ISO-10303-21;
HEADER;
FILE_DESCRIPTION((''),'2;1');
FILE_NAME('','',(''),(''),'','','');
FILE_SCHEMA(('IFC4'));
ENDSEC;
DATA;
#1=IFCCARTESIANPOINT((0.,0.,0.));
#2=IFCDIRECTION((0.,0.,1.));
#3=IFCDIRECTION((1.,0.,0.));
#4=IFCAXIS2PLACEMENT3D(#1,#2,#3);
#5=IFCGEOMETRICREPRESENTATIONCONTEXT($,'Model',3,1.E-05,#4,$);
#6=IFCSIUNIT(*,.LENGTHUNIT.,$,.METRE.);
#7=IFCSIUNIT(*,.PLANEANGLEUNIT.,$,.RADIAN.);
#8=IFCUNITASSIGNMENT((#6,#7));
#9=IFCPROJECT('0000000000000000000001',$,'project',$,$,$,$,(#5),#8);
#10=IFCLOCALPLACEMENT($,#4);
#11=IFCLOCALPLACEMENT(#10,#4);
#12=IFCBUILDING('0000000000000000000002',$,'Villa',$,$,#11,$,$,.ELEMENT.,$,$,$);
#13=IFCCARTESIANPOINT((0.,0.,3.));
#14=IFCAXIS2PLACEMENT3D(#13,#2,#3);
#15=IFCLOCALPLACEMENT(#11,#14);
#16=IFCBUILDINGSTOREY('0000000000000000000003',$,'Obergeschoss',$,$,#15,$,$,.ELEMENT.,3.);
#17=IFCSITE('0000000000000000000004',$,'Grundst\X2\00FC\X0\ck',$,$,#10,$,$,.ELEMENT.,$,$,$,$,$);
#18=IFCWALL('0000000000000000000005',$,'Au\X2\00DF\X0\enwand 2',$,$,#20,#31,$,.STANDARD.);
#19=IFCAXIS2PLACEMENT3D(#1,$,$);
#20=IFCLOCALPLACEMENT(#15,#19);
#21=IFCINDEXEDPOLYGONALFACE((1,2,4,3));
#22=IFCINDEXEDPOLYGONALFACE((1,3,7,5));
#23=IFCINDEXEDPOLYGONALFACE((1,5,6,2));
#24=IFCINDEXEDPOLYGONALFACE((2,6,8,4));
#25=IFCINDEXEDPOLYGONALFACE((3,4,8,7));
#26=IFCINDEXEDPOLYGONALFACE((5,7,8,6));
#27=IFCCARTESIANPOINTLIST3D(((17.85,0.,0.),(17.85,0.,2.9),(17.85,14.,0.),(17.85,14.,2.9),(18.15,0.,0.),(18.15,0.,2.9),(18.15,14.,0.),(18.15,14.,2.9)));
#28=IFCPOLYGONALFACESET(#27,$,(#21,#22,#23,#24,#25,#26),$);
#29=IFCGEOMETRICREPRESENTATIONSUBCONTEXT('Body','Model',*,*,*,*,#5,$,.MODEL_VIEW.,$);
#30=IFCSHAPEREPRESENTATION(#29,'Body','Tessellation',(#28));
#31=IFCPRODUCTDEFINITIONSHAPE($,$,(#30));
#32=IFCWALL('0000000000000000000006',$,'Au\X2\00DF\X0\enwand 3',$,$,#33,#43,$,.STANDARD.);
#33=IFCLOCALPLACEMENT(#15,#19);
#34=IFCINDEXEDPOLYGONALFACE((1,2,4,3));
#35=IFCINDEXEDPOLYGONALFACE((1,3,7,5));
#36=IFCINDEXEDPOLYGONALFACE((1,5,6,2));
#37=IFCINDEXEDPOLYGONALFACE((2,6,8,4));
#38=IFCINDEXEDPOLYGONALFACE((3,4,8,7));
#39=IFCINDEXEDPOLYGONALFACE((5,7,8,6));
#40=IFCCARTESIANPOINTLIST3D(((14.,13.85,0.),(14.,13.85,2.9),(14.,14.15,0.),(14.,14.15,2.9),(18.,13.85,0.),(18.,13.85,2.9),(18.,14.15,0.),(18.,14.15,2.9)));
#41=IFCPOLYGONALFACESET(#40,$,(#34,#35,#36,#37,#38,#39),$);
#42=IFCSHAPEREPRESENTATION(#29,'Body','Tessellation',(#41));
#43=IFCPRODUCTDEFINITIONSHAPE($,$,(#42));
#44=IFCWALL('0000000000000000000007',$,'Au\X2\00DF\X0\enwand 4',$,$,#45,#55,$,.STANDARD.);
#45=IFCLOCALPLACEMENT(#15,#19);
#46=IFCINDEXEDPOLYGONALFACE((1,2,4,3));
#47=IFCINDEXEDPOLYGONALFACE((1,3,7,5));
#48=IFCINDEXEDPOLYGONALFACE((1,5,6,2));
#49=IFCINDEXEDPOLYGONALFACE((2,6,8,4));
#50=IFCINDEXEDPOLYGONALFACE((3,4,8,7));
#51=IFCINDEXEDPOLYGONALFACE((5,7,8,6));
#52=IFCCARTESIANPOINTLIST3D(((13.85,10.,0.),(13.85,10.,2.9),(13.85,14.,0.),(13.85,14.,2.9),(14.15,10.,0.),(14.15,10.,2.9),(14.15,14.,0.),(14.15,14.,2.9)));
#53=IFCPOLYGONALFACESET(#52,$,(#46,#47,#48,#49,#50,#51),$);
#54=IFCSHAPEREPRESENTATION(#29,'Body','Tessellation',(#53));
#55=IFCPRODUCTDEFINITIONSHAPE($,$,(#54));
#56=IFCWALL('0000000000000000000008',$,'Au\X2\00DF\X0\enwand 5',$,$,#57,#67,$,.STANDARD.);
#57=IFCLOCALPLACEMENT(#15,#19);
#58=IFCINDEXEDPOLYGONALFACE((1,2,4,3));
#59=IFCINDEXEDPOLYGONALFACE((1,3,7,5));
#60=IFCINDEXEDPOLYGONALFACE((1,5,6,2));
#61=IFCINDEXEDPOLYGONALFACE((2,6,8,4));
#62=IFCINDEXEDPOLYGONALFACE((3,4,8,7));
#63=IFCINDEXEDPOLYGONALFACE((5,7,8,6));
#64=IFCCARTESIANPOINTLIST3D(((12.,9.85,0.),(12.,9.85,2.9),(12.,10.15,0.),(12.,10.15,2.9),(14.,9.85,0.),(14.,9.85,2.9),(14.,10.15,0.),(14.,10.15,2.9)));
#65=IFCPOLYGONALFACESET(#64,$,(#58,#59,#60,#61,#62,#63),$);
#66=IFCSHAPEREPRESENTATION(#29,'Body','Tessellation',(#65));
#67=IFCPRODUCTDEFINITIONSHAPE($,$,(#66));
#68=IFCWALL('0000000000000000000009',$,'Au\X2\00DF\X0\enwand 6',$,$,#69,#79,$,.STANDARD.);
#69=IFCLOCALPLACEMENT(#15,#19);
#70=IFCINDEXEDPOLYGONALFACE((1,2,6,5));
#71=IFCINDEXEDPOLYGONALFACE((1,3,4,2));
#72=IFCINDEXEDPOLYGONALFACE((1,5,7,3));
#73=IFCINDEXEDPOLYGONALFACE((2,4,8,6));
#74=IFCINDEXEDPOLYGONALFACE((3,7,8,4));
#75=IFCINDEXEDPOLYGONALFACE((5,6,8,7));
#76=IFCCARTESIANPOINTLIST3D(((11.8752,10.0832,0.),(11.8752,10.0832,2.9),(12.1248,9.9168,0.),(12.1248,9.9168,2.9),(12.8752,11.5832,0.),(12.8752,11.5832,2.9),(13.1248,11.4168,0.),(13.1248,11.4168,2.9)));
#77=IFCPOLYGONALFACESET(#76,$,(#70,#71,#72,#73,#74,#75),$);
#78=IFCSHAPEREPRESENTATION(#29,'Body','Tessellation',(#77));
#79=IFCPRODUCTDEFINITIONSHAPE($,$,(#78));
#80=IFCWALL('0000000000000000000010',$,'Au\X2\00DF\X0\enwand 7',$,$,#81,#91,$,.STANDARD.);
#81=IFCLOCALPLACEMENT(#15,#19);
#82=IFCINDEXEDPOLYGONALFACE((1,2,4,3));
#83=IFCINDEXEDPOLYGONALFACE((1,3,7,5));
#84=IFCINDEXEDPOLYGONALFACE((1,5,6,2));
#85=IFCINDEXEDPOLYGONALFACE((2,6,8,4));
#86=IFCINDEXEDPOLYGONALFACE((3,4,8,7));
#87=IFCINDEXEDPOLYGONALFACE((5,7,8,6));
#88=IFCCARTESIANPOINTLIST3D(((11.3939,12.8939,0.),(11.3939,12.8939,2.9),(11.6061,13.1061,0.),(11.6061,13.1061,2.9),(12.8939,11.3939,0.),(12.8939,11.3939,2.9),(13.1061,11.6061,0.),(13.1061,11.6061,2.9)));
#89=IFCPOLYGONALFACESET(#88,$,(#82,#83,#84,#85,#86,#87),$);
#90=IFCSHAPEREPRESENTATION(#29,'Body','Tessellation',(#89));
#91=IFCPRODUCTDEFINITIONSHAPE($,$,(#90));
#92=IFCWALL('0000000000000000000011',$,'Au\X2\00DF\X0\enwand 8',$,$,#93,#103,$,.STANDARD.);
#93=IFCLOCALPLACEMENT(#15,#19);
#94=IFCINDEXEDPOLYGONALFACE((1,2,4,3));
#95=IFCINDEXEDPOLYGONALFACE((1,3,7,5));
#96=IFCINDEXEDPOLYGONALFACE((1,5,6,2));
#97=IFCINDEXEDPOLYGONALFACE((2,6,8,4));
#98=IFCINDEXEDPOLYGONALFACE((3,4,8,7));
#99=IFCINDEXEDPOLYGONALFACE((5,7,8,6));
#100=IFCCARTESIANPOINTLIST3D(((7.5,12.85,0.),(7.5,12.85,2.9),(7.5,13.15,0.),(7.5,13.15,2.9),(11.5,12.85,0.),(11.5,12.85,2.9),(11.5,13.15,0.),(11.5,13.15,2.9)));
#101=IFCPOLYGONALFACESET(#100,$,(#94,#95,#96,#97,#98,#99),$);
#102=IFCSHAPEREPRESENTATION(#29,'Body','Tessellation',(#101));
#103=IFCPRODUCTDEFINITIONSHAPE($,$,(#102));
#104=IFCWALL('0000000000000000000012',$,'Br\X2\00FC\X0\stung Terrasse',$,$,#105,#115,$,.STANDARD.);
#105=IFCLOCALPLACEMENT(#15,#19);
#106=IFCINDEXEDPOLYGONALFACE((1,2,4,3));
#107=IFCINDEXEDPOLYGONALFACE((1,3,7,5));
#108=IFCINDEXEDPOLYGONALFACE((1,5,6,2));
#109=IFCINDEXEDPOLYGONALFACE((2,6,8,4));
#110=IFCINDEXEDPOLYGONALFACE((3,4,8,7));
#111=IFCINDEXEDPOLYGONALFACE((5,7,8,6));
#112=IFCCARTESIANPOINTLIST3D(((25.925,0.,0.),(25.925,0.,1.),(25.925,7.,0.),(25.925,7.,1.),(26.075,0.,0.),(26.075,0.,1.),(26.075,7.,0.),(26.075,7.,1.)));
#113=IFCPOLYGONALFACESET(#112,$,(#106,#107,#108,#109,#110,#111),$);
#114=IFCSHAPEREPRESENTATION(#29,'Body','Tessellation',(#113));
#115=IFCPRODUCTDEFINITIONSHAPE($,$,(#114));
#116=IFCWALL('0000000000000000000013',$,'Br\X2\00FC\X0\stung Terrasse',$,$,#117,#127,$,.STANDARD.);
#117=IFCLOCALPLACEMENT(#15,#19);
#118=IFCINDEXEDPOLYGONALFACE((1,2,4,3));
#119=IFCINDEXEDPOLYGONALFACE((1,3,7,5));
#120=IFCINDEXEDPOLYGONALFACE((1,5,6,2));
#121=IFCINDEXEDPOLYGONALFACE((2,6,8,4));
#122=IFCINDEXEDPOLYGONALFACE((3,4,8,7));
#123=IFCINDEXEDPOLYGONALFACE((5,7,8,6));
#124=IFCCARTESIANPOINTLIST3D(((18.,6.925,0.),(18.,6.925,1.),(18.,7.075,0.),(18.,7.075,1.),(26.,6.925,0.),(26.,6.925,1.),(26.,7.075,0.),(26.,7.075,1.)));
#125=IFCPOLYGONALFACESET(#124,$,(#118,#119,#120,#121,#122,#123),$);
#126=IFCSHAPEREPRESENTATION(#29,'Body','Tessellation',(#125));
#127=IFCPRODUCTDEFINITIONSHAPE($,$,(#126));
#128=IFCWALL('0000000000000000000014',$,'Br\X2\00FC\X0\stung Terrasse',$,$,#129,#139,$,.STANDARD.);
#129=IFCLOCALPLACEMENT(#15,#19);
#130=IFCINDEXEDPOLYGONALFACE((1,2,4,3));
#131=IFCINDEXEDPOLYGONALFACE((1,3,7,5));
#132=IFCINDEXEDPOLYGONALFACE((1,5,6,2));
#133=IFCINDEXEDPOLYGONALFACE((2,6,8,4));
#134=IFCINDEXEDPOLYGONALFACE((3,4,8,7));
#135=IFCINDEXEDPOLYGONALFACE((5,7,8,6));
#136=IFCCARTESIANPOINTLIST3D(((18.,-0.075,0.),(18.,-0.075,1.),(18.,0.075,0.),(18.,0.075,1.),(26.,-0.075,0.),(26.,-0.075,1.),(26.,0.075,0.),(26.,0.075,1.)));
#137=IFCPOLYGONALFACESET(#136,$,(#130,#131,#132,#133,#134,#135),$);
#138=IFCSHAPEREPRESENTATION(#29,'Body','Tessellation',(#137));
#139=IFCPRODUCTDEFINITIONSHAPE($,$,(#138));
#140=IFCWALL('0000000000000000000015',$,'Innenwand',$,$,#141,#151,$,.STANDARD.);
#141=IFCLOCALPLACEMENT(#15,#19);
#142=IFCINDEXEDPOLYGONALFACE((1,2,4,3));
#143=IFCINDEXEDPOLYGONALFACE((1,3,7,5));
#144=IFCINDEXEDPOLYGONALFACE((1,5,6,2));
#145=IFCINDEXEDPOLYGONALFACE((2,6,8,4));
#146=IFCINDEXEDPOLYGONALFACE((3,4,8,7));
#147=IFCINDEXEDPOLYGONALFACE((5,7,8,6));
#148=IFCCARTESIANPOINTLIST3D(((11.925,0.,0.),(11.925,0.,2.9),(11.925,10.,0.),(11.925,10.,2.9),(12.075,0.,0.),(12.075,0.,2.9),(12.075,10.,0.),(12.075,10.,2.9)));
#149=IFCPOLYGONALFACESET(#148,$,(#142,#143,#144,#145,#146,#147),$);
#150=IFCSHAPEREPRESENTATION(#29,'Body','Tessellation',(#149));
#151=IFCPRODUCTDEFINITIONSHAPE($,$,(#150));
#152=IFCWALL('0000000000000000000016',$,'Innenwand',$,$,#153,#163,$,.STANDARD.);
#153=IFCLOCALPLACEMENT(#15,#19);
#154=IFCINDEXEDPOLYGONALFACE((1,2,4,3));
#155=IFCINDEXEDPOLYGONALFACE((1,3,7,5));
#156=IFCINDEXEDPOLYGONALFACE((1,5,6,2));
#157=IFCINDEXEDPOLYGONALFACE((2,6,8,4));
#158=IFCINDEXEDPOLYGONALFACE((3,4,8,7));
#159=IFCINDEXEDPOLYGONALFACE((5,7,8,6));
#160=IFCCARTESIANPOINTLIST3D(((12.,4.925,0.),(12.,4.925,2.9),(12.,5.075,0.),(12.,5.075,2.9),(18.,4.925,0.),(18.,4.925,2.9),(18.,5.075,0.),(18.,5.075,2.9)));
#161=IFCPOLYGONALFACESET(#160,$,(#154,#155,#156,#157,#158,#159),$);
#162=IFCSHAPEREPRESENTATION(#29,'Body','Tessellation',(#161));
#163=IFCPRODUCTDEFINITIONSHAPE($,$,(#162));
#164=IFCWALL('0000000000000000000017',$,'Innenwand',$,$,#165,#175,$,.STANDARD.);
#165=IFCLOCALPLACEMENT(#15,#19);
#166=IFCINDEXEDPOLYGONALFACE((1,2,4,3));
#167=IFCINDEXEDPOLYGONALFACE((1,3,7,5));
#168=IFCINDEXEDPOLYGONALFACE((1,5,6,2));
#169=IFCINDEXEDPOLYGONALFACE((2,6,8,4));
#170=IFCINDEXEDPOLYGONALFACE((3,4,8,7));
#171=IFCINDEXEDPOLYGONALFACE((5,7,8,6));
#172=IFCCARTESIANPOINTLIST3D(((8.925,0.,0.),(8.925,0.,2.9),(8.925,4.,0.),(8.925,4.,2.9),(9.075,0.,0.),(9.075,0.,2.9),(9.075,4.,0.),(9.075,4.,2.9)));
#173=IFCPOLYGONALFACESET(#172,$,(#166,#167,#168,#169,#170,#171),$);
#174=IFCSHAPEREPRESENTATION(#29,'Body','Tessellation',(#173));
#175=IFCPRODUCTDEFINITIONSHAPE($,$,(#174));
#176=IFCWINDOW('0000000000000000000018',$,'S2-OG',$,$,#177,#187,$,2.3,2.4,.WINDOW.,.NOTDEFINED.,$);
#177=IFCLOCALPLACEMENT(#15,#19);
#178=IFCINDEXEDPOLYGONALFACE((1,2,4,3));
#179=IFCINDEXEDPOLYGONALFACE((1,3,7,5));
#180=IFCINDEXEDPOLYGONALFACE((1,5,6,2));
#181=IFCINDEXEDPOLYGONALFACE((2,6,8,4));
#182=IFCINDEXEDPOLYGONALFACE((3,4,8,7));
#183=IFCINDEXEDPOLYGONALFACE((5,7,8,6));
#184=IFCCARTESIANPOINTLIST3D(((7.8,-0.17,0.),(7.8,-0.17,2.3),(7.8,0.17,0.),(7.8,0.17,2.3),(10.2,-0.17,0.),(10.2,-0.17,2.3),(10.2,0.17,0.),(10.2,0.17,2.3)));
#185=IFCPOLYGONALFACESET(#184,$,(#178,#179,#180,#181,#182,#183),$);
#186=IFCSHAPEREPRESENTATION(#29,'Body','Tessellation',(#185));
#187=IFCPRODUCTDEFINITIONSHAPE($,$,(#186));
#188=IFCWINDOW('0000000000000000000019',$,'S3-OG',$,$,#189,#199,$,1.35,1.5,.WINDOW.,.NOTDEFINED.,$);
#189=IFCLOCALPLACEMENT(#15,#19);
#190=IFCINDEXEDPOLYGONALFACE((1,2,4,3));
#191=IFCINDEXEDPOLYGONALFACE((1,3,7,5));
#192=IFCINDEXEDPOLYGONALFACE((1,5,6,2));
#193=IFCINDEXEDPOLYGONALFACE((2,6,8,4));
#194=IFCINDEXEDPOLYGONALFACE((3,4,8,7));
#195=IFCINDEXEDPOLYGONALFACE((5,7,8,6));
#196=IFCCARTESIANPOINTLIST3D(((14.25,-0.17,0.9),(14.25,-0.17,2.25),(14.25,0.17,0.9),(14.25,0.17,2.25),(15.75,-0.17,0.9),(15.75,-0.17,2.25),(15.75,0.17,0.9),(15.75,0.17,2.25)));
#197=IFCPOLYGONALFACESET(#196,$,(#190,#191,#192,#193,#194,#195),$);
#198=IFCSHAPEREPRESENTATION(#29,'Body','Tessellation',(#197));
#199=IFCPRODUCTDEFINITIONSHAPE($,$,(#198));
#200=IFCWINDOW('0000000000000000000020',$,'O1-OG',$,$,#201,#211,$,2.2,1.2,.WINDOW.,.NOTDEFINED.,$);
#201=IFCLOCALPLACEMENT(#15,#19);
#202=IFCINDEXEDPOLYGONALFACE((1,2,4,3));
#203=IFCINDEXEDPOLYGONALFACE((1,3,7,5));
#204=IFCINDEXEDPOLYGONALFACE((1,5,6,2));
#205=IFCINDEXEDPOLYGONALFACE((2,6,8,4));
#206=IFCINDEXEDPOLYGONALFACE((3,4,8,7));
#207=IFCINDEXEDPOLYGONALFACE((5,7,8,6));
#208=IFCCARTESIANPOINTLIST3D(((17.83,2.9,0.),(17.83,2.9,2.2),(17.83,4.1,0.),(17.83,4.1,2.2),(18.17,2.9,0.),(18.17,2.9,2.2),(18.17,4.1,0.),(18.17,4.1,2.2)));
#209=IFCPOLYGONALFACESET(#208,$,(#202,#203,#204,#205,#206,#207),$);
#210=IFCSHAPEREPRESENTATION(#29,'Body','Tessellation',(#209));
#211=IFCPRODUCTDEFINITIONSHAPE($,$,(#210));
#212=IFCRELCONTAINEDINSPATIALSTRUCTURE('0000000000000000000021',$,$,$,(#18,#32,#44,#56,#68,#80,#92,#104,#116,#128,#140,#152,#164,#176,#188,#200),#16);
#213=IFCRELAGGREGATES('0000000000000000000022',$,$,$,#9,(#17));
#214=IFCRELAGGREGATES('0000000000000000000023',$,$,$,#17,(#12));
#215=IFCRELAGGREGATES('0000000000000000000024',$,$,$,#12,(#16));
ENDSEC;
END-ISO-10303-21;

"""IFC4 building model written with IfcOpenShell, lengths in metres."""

from ifc_helpers import new_model, si_unit, frame, frame_2d, origin_with_axes, origin_2d, place, context, subcontext, project, spatial, rectangle, extrude, element, save


model = new_model("IFC4")

# Units and contexts
model_context = context("Model", 3, precision=1e-05, world=origin_with_axes())
body_context = subcontext(model_context, "Body", "Model", "MODEL_VIEW")
ifc_project = project(units=[si_unit("LENGTHUNIT", "METRE"), si_unit("PLANEANGLEUNIT", "RADIAN")], contexts=[model_context])

# Site, building, storey
site_placement = place(None, origin_with_axes())
site = spatial("IfcSite", under=ifc_project, at=site_placement, Name="Grundstück", CompositionType="ELEMENT")
building_placement = place(site_placement, origin_with_axes())
building = spatial("IfcBuilding", under=site, at=building_placement, Name="Villa", CompositionType="ELEMENT")
storey_placement = place(building_placement, frame((0.0, 0.0, 3.0), z_axis=(0.0, 0.0, 1.0), x_axis=(1.0, 0.0, 0.0)))
storey = spatial("IfcBuildingStorey", under=building, at=storey_placement, Name="Obergeschoss", CompositionType="ELEMENT", Elevation=3.0)

# Walls
wall_1_placement = place(storey_placement, frame((18.0, 0.0, 0.0), z_axis=(0.0, 0.0, 1.0), x_axis=(0.0, 1.0, 0.0)))
element("IfcWall", 1, at=wall_1_placement, inside=storey, Name="Außenwand 2", PredefinedType="STANDARD", context=body_context, shape_type="SweptSolid", body=[
    extrude(rectangle(XDim=14.0, YDim=0.3, at=frame_2d((7.0, 0.0))), origin_with_axes(), (0.0, 0.0, 1.0), 2.9),
])
for number, where, z_axis, x_axis, name in (
    (2, (18.0, 14.0, 0.0), (0.0, 0.0, 1.0), (-1.0, 0.0, 0.0), "Außenwand 3"),
    (3, (14.0, 14.0, 0.0), (0.0, 0.0, 1.0), (0.0, -1.0, 0.0), "Außenwand 4"),
):
    element("IfcWall", number, at=place(storey_placement, frame(where, z_axis=z_axis, x_axis=x_axis)), inside=storey, Name=name, PredefinedType="STANDARD", context=body_context, shape_type="SweptSolid", body=[
        extrude(rectangle(XDim=4.0, YDim=0.3, at=frame_2d((2.0, 0.0))), origin_with_axes(), (0.0, 0.0, 1.0), 2.9),
    ])
wall_2_placement = place(storey_placement, frame((14.0, 10.0, 0.0), z_axis=(0.0, 0.0, 1.0), x_axis=(-1.0, 0.0, 0.0)))
element("IfcWall", 4, at=wall_2_placement, inside=storey, Name="Außenwand 5", PredefinedType="STANDARD", context=body_context, shape_type="SweptSolid", body=[
    extrude(rectangle(XDim=2.0, YDim=0.3, at=frame_2d((1.0, 0.0))), origin_with_axes(), (0.0, 0.0, 1.0), 2.9),
])
wall_3_placement = place(storey_placement, frame((12.0, 10.0, 0.0), z_axis=(0.0, 0.0, 1.0), x_axis=(0.5547, 0.83205, 0.0)))
element("IfcWall", 5, at=wall_3_placement, inside=storey, Name="Außenwand 6", PredefinedType="STANDARD", context=body_context, shape_type="SweptSolid", body=[
    extrude(rectangle(XDim=1.8028, YDim=0.3, at=frame_2d((0.9014, 0.0))), origin_with_axes(), (0.0, 0.0, 1.0), 2.9),
])
wall_4_placement = place(storey_placement, frame((13.0, 11.5, 0.0), z_axis=(0.0, 0.0, 1.0), x_axis=(-0.707107, 0.707107, 0.0)))
element("IfcWall", 6, at=wall_4_placement, inside=storey, Name="Außenwand 7", PredefinedType="STANDARD", context=body_context, shape_type="SweptSolid", body=[
    extrude(rectangle(XDim=2.1213, YDim=0.3, at=frame_2d((1.0607, 0.0))), origin_with_axes(), (0.0, 0.0, 1.0), 2.9),
])
wall_5_placement = place(storey_placement, frame((11.5, 13.0, 0.0), z_axis=(0.0, 0.0, 1.0), x_axis=(-1.0, 0.0, 0.0)))
element("IfcWall", 7, at=wall_5_placement, inside=storey, Name="Außenwand 8", PredefinedType="STANDARD", context=body_context, shape_type="SweptSolid", body=[
    extrude(rectangle(XDim=4.0, YDim=0.3, at=frame_2d((2.0, 0.0))), origin_with_axes(), (0.0, 0.0, 1.0), 2.9),
])
wall_6_placement = place(storey_placement, frame((26.0, 0.0, 0.0), z_axis=(0.0, 0.0, 1.0), x_axis=(0.0, 1.0, 0.0)))
element("IfcWall", 8, at=wall_6_placement, inside=storey, Name="Brüstung Terrasse", PredefinedType="STANDARD", context=body_context, shape_type="SweptSolid", body=[
    extrude(rectangle(XDim=7.0, YDim=0.15, at=frame_2d((3.5, 0.0))), origin_with_axes(), (0.0, 0.0, 1.0), 1.0),
])
for number, where, z_axis, x_axis, name in (
    (9, (26.0, 7.0, 0.0), (0.0, 0.0, 1.0), (-1.0, 0.0, 0.0), "Brüstung Terrasse"),
    (10, (18.0, 0.0, 0.0), (0.0, 0.0, 1.0), (1.0, 0.0, 0.0), "Brüstung Terrasse"),
):
    element("IfcWall", number, at=place(storey_placement, frame(where, z_axis=z_axis, x_axis=x_axis)), inside=storey, Name=name, PredefinedType="STANDARD", context=body_context, shape_type="SweptSolid", body=[
        extrude(rectangle(XDim=8.0, YDim=0.15, at=frame_2d((4.0, 0.0))), origin_with_axes(), (0.0, 0.0, 1.0), 1.0),
    ])
wall_7_placement = place(storey_placement, frame((12.0, 0.0, 0.0), z_axis=(0.0, 0.0, 1.0), x_axis=(0.0, 1.0, 0.0)))
element("IfcWall", 11, at=wall_7_placement, inside=storey, Name="Innenwand", PredefinedType="STANDARD", context=body_context, shape_type="SweptSolid", body=[
    extrude(rectangle(XDim=10.0, YDim=0.15, at=frame_2d((5.0, 0.0))), origin_with_axes(), (0.0, 0.0, 1.0), 2.9),
])
wall_8_placement = place(storey_placement, frame((12.0, 5.0, 0.0), z_axis=(0.0, 0.0, 1.0), x_axis=(1.0, 0.0, 0.0)))
element("IfcWall", 12, at=wall_8_placement, inside=storey, Name="Innenwand", PredefinedType="STANDARD", context=body_context, shape_type="SweptSolid", body=[
    extrude(rectangle(XDim=6.0, YDim=0.15, at=frame_2d((3.0, 0.0))), origin_with_axes(), (0.0, 0.0, 1.0), 2.9),
])
wall_9_placement = place(storey_placement, frame((9.0, 0.0, 0.0), z_axis=(0.0, 0.0, 1.0), x_axis=(0.0, 1.0, 0.0)))
element("IfcWall", 13, at=wall_9_placement, inside=storey, Name="Innenwand", PredefinedType="STANDARD", context=body_context, shape_type="SweptSolid", body=[
    extrude(rectangle(XDim=4.0, YDim=0.15, at=frame_2d((2.0, 0.0))), origin_with_axes(), (0.0, 0.0, 1.0), 2.9),
])

# Windows
window_1_placement = place(storey_placement, frame((9.0, 0.0, 0.0), z_axis=(0.0, 0.0, 1.0), x_axis=(1.0, 0.0, 0.0)))
element("IfcWindow", 14, at=window_1_placement, inside=storey, Name="S2-OG", OverallHeight=2.3, OverallWidth=2.4, PartitioningType="NOTDEFINED", PredefinedType="WINDOW", context=body_context, shape_type="SweptSolid", body=[
    extrude(rectangle(XDim=2.4, YDim=0.34, at=origin_2d()), origin_with_axes(), (0.0, 0.0, 1.0), 2.3),
])
window_2_placement = place(storey_placement, frame((15.0, 0.0, 0.9), z_axis=(0.0, 0.0, 1.0), x_axis=(1.0, 0.0, 0.0)))
element("IfcWindow", 15, at=window_2_placement, inside=storey, Name="S3-OG", OverallHeight=1.35, OverallWidth=1.5, PartitioningType="NOTDEFINED", PredefinedType="WINDOW", context=body_context, shape_type="SweptSolid", body=[
    extrude(rectangle(XDim=1.5, YDim=0.34, at=origin_2d()), origin_with_axes(), (0.0, 0.0, 1.0), 1.35),
])
window_3_placement = place(storey_placement, frame((18.0, 3.5, 0.0), z_axis=(0.0, 0.0, 1.0), x_axis=(0.0, 1.0, 0.0)))
element("IfcWindow", 16, at=window_3_placement, inside=storey, Name="O1-OG", OverallHeight=2.2, OverallWidth=1.2, PartitioningType="NOTDEFINED", PredefinedType="WINDOW", context=body_context, shape_type="SweptSolid", body=[
    extrude(rectangle(XDim=1.2, YDim=0.34, at=origin_2d()), origin_with_axes(), (0.0, 0.0, 1.0), 2.2),
])

save(model, "model.ifc")
